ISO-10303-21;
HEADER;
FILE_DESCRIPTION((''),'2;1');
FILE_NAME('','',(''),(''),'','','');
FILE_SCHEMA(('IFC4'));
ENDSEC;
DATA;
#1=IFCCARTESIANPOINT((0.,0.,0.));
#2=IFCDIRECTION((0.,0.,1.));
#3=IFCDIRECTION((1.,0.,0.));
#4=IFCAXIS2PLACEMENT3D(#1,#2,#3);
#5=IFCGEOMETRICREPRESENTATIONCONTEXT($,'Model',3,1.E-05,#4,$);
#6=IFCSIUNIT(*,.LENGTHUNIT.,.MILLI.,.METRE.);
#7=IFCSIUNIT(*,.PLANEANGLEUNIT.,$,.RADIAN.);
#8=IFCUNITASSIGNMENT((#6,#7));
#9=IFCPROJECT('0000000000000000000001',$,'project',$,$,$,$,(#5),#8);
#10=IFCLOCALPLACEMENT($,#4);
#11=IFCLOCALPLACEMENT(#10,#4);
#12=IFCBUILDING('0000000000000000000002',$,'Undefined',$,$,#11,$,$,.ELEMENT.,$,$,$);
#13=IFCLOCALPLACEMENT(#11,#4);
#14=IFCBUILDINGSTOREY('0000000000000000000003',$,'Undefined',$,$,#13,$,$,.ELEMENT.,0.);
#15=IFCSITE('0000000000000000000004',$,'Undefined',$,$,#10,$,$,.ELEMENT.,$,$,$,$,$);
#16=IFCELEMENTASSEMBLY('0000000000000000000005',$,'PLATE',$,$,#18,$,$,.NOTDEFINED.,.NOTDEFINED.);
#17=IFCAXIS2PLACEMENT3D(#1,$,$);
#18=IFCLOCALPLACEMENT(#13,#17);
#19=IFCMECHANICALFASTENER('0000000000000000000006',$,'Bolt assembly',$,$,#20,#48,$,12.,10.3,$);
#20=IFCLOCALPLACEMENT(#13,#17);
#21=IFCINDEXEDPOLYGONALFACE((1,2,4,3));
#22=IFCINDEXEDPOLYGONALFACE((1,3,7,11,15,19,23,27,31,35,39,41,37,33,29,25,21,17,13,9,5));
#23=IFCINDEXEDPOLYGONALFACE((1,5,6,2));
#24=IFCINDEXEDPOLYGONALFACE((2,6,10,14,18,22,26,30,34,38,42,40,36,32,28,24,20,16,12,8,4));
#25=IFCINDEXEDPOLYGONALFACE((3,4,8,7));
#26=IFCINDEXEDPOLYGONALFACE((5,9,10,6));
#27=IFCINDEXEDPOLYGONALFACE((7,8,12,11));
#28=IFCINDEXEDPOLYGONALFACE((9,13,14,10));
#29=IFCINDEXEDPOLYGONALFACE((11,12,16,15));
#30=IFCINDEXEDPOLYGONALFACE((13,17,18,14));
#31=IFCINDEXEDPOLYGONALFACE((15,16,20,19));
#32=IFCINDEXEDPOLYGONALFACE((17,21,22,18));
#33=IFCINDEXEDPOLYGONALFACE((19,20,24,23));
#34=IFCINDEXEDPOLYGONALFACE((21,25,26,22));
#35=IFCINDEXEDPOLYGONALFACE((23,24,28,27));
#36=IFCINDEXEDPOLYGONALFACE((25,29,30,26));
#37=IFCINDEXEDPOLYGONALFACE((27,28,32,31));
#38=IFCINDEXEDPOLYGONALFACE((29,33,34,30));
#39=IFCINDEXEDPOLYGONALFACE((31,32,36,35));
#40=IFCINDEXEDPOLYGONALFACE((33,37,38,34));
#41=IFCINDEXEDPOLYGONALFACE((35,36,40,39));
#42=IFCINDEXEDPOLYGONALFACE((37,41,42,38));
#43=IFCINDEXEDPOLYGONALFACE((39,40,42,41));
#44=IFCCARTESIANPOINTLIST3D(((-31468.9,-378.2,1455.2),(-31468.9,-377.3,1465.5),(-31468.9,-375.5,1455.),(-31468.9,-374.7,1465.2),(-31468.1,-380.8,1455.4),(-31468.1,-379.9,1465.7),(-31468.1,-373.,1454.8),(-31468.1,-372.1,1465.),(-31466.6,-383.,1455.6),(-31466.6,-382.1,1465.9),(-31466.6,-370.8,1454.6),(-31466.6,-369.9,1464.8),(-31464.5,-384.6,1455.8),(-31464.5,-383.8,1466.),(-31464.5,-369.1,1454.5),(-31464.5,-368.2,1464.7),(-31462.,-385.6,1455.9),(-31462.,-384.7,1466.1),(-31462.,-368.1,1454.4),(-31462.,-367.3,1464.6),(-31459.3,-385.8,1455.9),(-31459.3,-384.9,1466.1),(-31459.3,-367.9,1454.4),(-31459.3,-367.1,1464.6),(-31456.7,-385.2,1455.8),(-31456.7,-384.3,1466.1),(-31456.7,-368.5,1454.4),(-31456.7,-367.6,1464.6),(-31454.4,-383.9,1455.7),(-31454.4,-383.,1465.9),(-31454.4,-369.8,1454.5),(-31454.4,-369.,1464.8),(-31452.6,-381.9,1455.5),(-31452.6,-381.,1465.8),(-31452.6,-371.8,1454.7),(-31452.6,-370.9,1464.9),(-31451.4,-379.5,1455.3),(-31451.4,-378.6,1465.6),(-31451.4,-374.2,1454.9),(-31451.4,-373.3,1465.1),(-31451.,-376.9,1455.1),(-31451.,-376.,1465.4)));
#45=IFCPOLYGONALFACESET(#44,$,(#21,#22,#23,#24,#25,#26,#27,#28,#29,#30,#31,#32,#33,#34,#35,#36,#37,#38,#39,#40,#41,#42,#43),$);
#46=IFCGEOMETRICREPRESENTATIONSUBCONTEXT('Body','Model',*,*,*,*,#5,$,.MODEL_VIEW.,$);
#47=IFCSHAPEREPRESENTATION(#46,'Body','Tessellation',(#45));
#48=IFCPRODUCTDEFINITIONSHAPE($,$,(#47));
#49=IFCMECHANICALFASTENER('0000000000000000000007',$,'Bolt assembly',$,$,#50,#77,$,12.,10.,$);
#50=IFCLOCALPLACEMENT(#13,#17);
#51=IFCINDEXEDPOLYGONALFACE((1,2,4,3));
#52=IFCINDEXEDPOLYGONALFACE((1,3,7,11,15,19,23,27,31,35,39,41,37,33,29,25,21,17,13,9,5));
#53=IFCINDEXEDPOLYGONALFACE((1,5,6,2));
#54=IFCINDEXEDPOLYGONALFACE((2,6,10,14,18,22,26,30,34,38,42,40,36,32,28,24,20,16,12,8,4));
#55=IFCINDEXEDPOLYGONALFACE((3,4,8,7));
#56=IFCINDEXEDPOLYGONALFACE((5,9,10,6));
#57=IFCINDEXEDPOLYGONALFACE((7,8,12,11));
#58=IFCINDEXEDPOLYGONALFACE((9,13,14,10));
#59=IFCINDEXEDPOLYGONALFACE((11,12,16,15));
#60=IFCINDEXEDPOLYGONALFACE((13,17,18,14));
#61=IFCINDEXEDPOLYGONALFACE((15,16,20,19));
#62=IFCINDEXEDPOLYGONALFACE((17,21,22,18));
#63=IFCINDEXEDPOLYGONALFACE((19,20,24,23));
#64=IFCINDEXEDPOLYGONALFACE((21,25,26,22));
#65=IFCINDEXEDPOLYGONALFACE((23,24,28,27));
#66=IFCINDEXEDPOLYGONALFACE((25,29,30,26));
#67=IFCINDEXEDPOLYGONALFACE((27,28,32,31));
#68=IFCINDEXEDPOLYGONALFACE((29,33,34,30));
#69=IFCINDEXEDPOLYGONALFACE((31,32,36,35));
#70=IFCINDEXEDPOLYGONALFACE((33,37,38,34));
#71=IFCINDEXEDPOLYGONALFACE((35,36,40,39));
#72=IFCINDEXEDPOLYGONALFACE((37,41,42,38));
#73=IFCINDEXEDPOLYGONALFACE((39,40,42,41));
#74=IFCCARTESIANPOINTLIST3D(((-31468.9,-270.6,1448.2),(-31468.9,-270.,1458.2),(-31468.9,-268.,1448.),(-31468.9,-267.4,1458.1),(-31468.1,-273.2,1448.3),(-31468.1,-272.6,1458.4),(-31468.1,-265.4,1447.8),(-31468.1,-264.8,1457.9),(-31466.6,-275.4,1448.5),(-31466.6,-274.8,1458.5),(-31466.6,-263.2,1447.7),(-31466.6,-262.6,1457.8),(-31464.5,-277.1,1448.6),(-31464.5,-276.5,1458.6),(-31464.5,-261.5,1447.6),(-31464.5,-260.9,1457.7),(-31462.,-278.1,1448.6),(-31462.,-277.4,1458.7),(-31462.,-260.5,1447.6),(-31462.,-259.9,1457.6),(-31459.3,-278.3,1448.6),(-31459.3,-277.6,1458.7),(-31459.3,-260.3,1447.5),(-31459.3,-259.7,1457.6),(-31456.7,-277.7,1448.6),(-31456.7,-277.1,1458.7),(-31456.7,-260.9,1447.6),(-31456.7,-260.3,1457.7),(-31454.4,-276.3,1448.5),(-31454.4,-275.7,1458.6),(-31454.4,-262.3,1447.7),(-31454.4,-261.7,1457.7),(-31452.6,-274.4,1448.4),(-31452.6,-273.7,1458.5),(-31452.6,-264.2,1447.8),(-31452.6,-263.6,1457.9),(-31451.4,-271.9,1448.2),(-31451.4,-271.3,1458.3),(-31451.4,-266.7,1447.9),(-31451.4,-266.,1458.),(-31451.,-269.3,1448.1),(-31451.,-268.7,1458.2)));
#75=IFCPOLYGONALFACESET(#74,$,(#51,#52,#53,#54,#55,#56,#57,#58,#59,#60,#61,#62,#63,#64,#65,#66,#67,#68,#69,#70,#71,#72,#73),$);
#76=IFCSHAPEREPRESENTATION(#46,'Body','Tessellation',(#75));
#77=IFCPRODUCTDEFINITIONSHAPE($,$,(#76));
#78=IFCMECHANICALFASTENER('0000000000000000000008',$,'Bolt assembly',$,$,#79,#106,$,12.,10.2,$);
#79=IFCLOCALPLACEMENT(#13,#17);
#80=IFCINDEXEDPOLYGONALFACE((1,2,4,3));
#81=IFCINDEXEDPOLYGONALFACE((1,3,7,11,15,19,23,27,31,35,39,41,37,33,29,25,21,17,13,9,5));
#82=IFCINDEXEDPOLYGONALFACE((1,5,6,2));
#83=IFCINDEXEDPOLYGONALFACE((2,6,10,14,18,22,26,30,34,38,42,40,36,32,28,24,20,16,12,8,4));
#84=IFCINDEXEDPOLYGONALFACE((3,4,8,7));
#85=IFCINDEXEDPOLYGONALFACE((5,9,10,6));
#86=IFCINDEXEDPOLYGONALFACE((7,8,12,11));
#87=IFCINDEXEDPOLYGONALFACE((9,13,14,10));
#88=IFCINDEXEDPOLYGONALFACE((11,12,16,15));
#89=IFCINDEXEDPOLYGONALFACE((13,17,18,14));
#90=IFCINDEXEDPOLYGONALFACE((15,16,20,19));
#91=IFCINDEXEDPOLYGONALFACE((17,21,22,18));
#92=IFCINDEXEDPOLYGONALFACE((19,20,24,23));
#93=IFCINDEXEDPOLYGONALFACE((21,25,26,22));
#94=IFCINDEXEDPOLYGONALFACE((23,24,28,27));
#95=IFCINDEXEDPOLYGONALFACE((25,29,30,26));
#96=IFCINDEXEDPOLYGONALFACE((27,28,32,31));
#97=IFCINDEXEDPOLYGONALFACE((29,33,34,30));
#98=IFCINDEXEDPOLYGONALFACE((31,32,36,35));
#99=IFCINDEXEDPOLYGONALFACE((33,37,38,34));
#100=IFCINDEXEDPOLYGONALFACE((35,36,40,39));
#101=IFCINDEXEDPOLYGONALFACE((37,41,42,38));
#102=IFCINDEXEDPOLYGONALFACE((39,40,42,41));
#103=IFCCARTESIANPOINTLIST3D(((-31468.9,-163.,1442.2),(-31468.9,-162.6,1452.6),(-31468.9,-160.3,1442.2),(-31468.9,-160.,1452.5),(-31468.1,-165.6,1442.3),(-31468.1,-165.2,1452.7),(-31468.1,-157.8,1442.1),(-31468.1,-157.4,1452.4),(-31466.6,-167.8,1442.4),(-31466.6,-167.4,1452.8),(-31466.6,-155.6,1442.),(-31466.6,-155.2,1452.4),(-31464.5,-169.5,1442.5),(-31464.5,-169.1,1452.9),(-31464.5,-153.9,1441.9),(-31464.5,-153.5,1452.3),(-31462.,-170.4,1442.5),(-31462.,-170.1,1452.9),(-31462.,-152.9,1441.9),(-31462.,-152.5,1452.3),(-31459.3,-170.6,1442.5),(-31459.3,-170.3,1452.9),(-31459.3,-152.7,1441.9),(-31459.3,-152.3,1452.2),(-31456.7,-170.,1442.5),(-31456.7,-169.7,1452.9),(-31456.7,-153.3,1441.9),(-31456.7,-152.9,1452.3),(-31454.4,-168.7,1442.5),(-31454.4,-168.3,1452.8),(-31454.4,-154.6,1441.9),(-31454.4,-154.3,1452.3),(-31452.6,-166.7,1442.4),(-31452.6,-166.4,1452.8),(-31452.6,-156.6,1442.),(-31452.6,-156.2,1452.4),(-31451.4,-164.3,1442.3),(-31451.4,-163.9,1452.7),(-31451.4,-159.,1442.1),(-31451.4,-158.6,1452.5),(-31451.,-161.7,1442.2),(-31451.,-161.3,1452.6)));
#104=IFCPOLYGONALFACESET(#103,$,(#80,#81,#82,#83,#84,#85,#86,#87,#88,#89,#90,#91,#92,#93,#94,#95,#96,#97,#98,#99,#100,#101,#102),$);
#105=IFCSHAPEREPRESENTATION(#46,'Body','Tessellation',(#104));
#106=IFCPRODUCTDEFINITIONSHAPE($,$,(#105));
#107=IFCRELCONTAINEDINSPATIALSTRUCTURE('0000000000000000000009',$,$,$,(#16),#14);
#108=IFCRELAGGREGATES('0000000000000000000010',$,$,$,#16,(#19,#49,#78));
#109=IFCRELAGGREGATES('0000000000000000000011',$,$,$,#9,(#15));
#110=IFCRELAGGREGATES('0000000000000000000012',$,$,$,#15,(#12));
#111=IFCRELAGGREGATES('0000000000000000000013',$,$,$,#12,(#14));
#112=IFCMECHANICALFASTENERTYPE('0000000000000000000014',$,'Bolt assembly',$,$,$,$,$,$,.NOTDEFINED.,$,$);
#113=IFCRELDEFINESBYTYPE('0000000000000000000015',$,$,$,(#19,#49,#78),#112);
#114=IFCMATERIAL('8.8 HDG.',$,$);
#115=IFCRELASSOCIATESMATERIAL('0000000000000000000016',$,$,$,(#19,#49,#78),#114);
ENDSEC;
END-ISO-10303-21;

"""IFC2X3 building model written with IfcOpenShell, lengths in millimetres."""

from ifc_helpers import new_model, si_unit, frame, origin_with_axes, origin_2d_with_axis, place, context, subcontext, project, spatial, circle, extrude, source, transform, mapped, material, type_object, element, aggregate, save


model = new_model("IFC2X3")

# Units and contexts
model_context = context("Model", 3, precision=1e-05, world=origin_with_axes())
body_context = subcontext(model_context, "Body", "Model", "MODEL_VIEW")
ifc_project = project(units=[si_unit("LENGTHUNIT", "METRE", prefix="MILLI"), si_unit("PLANEANGLEUNIT", "RADIAN")], contexts=[model_context])

# Site, building, storey
site_placement = place(None, origin_with_axes())
site = spatial("IfcSite", under=ifc_project, at=site_placement, Name="Undefined", CompositionType="ELEMENT")
building_placement = place(site_placement, origin_with_axes())
building = spatial("IfcBuilding", under=site, at=building_placement, Name="Undefined", CompositionType="ELEMENT")
storey_placement = place(building_placement, origin_with_axes())
storey = spatial("IfcBuildingStorey", under=building, at=storey_placement, Name="Undefined", CompositionType="ELEMENT", Elevation=0.0)

# Element assembly, mechanical fasteners
assembly_placement = place(storey_placement, origin_with_axes())
assembly = element("IfcElementAssembly", 1, at=assembly_placement, inside=storey, Name="PLATE", AssemblyPlace="NOTDEFINED", PredefinedType="NOTDEFINED")
ifc_material_1 = material(Name="8.8 HDG.")
mechanical_fastener_type = type_object("IfcMechanicalFastenerType", Name="Bolt assembly")
shared_shape_1 = source(origin_with_axes(), body_context, "Body", "SweptSolid", [
    extrude(circle(Radius=9.0, at=origin_2d_with_axis()), frame((0.0, 0.1, 0.0), z_axis=(0.0, 1.0, 0.0), x_axis=(1.0, 0.0, 0.0)), (0.0, 0.0, 1.0), 10.3),
])
mechanical_fastener_1_placement = place(assembly_placement, frame((-31460.0, -376.9, 1455.0), z_axis=(0.000001, -0.996425, 0.084481), x_axis=(1.0, 0.000001, -0.000001)))
mechanical_fastener_1 = element("IfcMechanicalFastener", 2, at=mechanical_fastener_1_placement, type_object=mechanical_fastener_type, material=ifc_material_1, Name="Bolt assembly", NominalDiameter=12.0, NominalLength=10.3, context=body_context, shape_type="MappedRepresentation", body=[
    mapped(shared_shape_1, transform((0.0, 0.0, 0.0))),
])
shared_shape_2 = source(origin_with_axes(), body_context, "Body", "SweptSolid", [
    extrude(circle(Radius=9.0, at=origin_2d_with_axis()), frame((0.0, 0.9, 0.0), z_axis=(0.0, 1.0, 0.0), x_axis=(1.0, 0.0, 0.0)), (0.0, 0.0, 1.0), 10.1),
])
mechanical_fastener_2_placement = place(assembly_placement, frame((-31460.0, -269.4, 1447.2), z_axis=(0.000001, -0.998176, 0.060379), x_axis=(1.0, 0.000001, -0.000001)))
mechanical_fastener_2 = element("IfcMechanicalFastener", 3, at=mechanical_fastener_2_placement, type_object=mechanical_fastener_type, material=ifc_material_1, Name="Bolt assembly", NominalDiameter=12.0, NominalLength=10.0, context=body_context, shape_type="MappedRepresentation", body=[
    mapped(shared_shape_2, transform((0.0, 0.0, 0.0))),
])
shared_shape_3 = source(origin_with_axes(), body_context, "Body", "SweptSolid", [
    extrude(circle(Radius=9.0, at=origin_2d_with_axis()), frame((0.0, 0.2, 0.0), z_axis=(0.0, 1.0, 0.0), x_axis=(1.0, 0.0, 0.0)), (0.0, 0.0, 1.0), 10.4),
])
mechanical_fastener_3_placement = place(assembly_placement, frame((-31460.0, -161.7, 1442.0), z_axis=(0.000001, -0.999343, 0.036241), x_axis=(1.0, 0.000001, -0.000001)))
mechanical_fastener_3 = element("IfcMechanicalFastener", 4, at=mechanical_fastener_3_placement, type_object=mechanical_fastener_type, material=ifc_material_1, Name="Bolt assembly", NominalDiameter=12.0, NominalLength=10.2, context=body_context, shape_type="MappedRepresentation", body=[
    mapped(shared_shape_3, transform((0.0, 0.0, 0.0))),
])
aggregate(assembly, [mechanical_fastener_1, mechanical_fastener_2, mechanical_fastener_3])

save(model, "model.ifc")
